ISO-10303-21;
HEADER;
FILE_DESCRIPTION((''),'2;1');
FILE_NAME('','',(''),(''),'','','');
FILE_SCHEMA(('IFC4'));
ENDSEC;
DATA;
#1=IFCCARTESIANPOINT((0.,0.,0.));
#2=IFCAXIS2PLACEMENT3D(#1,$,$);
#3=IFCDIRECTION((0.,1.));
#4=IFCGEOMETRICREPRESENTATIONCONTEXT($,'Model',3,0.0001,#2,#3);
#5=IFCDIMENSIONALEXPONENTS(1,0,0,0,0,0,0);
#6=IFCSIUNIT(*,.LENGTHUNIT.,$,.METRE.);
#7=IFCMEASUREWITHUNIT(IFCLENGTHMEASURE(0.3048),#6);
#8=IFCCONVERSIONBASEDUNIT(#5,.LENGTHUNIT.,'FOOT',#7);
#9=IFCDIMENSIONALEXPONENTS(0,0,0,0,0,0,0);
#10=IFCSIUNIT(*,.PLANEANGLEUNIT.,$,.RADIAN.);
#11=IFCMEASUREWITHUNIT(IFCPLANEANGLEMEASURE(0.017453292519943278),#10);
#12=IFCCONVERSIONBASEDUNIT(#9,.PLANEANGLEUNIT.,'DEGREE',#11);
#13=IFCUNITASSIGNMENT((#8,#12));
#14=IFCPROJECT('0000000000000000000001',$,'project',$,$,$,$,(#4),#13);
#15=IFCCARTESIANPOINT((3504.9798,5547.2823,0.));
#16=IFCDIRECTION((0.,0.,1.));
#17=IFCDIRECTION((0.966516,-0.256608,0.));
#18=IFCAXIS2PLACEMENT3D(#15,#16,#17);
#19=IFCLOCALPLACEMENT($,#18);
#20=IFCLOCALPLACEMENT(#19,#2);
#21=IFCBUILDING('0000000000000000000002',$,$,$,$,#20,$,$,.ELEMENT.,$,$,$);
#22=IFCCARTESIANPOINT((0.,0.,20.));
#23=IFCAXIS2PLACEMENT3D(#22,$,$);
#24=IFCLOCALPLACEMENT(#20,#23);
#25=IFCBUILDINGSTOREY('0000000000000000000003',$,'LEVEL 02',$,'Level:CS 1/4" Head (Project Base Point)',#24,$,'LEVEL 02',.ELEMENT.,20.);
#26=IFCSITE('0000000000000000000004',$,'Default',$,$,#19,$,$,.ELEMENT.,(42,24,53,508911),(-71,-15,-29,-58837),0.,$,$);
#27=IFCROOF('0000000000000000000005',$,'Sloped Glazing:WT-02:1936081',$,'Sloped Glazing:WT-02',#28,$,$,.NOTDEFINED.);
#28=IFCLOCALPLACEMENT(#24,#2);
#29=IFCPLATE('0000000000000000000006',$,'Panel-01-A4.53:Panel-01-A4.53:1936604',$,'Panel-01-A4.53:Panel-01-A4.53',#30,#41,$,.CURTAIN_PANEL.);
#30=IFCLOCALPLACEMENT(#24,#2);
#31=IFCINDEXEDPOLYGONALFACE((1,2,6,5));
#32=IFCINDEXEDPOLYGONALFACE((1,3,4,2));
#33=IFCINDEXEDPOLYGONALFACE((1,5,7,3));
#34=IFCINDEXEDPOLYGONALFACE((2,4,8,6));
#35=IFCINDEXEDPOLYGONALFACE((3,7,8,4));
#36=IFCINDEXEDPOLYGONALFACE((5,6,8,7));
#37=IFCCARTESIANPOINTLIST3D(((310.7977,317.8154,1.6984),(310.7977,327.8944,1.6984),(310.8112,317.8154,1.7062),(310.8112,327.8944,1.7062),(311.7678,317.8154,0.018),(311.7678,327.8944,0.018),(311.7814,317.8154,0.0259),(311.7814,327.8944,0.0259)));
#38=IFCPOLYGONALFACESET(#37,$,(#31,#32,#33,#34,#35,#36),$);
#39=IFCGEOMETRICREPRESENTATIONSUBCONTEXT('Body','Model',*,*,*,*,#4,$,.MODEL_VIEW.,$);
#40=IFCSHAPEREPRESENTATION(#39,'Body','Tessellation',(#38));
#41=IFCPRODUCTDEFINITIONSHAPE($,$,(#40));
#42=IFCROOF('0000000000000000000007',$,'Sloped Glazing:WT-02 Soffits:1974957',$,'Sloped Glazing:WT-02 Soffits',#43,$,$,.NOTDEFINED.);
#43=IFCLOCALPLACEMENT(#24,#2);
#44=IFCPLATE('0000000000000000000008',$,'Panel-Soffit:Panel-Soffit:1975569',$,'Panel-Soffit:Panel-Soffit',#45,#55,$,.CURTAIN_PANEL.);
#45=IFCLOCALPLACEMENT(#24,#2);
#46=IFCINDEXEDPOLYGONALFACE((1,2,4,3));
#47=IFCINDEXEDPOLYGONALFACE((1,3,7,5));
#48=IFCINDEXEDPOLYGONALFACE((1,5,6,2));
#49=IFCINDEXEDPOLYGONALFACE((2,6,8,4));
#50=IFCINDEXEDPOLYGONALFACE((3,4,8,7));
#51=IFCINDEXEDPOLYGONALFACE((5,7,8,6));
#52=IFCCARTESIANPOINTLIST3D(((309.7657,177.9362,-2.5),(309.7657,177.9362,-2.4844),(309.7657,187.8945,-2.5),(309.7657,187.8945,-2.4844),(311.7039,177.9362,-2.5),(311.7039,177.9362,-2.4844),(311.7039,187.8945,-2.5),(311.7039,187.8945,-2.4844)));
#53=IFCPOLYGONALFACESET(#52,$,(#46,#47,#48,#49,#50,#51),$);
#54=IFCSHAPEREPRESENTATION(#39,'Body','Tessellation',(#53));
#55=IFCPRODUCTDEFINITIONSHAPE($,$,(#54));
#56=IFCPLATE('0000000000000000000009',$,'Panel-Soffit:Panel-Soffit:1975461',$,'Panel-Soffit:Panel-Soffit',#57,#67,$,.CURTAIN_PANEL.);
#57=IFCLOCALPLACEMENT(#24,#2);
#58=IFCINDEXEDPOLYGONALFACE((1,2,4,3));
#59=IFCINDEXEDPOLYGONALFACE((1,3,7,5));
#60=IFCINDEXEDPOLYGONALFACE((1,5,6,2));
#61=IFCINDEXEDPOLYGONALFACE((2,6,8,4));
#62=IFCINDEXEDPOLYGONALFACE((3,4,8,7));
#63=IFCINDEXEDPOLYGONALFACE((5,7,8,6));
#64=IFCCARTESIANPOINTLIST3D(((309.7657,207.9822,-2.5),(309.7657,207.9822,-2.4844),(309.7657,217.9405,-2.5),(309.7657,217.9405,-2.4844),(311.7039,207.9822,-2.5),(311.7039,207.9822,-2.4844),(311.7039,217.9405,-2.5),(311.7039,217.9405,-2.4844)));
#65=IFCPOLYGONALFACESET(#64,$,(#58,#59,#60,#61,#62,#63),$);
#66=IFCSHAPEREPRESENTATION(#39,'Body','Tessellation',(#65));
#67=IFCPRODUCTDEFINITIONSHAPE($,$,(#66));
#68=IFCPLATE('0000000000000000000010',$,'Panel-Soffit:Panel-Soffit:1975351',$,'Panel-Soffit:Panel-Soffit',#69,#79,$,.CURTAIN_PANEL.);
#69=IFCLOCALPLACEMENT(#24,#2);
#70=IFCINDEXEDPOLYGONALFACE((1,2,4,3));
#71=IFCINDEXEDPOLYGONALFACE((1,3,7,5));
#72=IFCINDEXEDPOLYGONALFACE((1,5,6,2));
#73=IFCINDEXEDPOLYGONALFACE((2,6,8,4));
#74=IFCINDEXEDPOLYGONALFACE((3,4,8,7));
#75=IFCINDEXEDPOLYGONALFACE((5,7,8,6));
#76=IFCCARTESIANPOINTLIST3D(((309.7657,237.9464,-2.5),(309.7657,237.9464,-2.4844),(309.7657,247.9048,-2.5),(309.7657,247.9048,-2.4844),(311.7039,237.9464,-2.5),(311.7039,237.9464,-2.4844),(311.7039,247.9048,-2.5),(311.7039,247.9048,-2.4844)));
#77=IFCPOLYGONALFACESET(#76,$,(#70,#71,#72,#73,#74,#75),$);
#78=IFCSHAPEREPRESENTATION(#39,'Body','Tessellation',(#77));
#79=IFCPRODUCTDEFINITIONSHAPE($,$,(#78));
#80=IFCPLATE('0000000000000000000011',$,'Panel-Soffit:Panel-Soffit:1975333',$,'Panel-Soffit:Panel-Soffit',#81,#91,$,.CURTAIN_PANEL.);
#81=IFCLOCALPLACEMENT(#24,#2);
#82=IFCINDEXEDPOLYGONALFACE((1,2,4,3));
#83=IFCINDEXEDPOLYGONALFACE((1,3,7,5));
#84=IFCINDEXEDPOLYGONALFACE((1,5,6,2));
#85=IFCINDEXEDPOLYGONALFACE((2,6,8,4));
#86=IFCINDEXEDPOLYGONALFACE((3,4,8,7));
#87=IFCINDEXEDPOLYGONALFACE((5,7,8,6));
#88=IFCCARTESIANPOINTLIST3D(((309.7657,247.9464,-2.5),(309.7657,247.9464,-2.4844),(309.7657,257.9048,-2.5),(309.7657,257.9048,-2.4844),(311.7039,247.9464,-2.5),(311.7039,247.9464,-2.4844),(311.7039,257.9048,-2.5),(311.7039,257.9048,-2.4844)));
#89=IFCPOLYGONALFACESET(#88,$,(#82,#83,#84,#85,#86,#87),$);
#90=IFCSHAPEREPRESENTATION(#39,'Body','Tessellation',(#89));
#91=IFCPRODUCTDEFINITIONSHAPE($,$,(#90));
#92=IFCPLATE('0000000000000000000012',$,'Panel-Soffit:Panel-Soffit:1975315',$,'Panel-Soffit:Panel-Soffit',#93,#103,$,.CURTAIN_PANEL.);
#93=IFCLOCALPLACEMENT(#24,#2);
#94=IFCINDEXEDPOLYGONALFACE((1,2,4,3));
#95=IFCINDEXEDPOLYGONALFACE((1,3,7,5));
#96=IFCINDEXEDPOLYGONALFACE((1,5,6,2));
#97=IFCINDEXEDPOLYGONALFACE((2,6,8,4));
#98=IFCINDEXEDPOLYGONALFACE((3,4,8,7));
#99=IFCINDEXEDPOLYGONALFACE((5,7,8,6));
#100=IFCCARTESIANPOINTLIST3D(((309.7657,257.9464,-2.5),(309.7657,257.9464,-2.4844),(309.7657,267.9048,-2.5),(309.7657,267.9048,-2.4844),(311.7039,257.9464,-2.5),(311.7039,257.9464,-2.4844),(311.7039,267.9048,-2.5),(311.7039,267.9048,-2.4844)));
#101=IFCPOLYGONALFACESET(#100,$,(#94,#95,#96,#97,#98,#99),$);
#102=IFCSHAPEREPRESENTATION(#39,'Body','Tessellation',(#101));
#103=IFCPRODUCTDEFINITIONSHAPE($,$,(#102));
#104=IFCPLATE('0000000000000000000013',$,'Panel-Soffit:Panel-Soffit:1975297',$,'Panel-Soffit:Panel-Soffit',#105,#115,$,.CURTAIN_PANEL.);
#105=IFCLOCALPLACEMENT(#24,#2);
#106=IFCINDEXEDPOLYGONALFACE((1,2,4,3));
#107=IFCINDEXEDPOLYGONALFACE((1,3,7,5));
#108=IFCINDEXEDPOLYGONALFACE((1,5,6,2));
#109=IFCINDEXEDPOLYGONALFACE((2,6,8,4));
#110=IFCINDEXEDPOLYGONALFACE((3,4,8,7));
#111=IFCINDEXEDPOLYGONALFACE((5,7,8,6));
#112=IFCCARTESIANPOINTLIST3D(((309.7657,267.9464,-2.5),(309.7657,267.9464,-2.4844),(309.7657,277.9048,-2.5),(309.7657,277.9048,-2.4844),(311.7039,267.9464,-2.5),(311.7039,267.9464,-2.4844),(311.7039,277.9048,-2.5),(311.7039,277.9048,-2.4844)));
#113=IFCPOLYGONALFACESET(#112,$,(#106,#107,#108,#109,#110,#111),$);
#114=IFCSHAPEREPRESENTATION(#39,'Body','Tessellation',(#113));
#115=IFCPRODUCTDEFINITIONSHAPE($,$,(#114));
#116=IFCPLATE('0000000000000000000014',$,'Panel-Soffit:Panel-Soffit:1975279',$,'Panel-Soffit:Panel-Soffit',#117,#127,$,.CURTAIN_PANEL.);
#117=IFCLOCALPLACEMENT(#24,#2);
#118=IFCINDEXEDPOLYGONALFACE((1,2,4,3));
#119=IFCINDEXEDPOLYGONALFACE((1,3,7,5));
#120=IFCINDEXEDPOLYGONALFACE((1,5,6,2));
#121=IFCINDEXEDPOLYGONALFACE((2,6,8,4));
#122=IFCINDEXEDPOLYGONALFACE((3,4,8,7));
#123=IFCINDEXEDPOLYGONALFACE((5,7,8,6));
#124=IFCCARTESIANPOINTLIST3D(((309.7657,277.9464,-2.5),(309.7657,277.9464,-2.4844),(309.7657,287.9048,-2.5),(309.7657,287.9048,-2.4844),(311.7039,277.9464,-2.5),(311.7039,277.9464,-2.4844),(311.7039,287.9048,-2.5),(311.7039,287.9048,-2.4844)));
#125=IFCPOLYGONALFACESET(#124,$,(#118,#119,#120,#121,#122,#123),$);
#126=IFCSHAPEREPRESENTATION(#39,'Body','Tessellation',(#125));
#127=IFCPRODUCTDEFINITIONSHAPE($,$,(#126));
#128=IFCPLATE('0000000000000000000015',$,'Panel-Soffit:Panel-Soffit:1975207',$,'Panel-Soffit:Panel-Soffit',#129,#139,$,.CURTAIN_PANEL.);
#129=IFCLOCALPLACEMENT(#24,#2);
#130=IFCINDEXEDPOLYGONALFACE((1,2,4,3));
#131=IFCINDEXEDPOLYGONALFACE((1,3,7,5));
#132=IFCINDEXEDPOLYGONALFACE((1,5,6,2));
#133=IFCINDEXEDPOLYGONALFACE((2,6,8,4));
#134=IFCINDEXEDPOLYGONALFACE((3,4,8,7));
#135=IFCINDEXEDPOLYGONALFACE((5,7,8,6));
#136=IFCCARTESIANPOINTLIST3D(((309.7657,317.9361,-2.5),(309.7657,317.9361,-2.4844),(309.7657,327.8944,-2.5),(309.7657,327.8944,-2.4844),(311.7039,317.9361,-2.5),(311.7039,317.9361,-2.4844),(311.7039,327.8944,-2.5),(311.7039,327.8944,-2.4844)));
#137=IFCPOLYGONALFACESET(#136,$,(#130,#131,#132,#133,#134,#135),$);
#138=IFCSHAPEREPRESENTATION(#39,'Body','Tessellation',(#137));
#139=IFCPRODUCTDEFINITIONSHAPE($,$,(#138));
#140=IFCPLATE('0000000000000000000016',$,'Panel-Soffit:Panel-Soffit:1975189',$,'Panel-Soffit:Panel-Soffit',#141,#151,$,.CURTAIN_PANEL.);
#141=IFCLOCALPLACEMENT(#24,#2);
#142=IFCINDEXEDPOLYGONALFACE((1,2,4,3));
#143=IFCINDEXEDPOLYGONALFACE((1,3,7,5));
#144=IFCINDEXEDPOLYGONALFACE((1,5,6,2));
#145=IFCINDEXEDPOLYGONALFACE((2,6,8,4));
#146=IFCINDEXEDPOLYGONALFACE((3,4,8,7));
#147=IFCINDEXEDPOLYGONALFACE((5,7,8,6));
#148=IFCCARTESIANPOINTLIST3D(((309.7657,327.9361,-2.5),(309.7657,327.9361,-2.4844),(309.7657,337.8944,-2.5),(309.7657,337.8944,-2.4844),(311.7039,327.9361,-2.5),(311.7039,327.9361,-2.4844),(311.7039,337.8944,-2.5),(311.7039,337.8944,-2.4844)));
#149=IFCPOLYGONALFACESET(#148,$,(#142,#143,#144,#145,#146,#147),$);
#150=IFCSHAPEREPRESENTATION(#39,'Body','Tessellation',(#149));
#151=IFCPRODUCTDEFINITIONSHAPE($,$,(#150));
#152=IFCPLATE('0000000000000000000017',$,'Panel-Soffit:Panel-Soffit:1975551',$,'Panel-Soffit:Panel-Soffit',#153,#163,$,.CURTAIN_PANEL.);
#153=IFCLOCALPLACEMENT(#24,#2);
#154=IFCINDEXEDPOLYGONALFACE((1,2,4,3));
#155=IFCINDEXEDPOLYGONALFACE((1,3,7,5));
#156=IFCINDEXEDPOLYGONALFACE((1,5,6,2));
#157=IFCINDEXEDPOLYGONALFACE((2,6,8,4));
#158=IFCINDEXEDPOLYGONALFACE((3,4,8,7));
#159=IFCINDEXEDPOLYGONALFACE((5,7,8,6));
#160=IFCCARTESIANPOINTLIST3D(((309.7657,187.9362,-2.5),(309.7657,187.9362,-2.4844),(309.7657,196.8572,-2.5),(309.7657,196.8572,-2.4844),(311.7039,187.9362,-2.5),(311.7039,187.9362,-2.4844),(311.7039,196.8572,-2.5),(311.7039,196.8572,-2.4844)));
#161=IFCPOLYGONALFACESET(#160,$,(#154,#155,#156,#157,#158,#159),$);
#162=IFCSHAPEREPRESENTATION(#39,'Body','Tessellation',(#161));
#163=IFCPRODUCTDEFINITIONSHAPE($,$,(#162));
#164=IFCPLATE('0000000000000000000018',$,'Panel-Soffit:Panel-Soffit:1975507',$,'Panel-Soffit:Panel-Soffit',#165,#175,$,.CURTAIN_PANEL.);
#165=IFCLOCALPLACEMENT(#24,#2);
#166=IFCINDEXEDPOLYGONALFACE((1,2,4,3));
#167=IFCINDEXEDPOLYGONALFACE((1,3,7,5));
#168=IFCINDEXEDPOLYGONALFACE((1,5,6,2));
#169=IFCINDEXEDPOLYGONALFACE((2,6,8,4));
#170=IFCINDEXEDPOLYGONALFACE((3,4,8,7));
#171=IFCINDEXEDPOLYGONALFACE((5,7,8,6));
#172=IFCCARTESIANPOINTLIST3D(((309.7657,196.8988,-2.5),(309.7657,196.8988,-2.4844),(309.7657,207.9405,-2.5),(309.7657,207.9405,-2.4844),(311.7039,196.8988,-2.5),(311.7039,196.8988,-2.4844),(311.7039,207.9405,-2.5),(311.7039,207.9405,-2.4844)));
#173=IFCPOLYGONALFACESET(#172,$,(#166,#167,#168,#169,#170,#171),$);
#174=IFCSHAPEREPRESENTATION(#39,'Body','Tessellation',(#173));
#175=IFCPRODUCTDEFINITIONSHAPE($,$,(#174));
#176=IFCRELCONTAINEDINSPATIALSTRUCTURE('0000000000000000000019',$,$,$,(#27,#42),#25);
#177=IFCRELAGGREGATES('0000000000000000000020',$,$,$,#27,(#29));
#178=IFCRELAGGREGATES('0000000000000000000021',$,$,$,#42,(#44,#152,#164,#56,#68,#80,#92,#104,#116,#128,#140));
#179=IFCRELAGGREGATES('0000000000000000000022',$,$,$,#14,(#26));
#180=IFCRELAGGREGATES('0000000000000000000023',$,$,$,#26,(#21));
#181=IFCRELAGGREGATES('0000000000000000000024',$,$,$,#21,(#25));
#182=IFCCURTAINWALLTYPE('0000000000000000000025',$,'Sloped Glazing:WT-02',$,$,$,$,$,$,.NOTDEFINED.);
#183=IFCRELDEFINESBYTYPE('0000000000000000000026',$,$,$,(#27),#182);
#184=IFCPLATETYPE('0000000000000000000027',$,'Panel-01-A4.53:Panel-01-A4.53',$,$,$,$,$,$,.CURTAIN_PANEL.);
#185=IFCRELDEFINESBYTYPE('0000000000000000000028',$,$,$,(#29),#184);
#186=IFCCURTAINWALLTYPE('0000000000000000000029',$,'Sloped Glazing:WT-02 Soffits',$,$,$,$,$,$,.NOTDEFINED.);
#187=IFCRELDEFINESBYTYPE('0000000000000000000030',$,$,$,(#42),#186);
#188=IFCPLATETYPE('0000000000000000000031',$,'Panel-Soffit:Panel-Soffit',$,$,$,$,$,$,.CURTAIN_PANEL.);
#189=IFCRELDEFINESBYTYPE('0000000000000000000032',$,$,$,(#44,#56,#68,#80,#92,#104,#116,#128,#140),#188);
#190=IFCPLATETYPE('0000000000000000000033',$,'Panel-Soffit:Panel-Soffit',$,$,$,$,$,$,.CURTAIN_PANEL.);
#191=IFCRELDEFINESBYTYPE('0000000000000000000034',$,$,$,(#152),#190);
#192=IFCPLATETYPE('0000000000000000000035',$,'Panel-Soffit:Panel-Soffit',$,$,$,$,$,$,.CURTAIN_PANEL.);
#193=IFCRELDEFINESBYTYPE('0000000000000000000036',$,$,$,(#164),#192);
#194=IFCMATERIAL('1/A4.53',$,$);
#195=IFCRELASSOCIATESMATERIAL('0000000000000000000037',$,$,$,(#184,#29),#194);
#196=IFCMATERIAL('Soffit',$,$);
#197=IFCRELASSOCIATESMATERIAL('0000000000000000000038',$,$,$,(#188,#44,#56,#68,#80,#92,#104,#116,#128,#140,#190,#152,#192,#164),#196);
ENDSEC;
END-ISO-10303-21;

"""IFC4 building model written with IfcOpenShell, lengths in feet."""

from ifc_helpers import new_model, entity, si_unit, converted_unit, direction, frame, origin, place, context, subcontext, project, spatial, indexed_curve, outline, extrude, source, transform, mapped, material, type_object, type_shapes, element, aggregate, save


model = new_model("IFC4")

# Units and contexts
model_context = context("Model", 3, precision=0.0001, world=origin(), true_north=direction((0.0, 1.0)))
body_context = subcontext(model_context, "Body", "Model", "MODEL_VIEW")
ifc_project = project(units=[converted_unit("LENGTHUNIT", "FOOT", entity("IfcLengthMeasure", 0.3048), si_unit("LENGTHUNIT", "METRE"), dimensions=[1, 0, 0, 0, 0, 0, 0]), converted_unit("PLANEANGLEUNIT", "DEGREE", entity("IfcPlaneAngleMeasure", 0.017453292519943278), si_unit("PLANEANGLEUNIT", "RADIAN"), dimensions=[0, 0, 0, 0, 0, 0, 0])], contexts=[model_context])

# Site, building, storey
site_placement = place(None, frame((3504.9798, 5547.2823, 0.0), z_axis=(0.0, 0.0, 1.0), x_axis=(0.966516, -0.256608, 0.0)))
site = spatial("IfcSite", under=ifc_project, at=site_placement, Name="Default", CompositionType="ELEMENT", RefLatitude=(42, 24, 53, 508911), RefLongitude=(-71, -15, -29, -58837), RefElevation=0.0)
building_placement = place(site_placement, origin())
building = spatial("IfcBuilding", under=site, at=building_placement, CompositionType="ELEMENT")
storey_placement = place(building_placement, frame((0.0, 0.0, 20.0)))
storey = spatial("IfcBuildingStorey", under=building, at=storey_placement, Name="LEVEL 02", ObjectType="Level:CS 1/4\" Head (Project Base Point)", LongName="LEVEL 02", CompositionType="ELEMENT", Elevation=20.0)

# Shared definitions
curtain_wall_type_1 = type_object("IfcCurtainWallType", Name="Sloped Glazing:WT-02 Soffits", PredefinedType="NOTDEFINED")
ifc_material_1 = material(Name="Soffit")

# Roof, plate
curtain_wall_type_2 = type_object("IfcCurtainWallType", Name="Sloped Glazing:WT-02", PredefinedType="NOTDEFINED")
roof_1_placement = place(storey_placement, frame((0.0, 0.0, -20.0)))
roof_1 = element("IfcRoof", 1, at=roof_1_placement, inside=storey, type_object=curtain_wall_type_2, Name="Sloped Glazing:WT-02:1936081", ObjectType="Sloped Glazing:WT-02", PredefinedType="NOTDEFINED")
ifc_material_2 = material(Name="1/A4.53")
plate_type_1 = type_object("IfcPlateType", Name="Panel-01-A4.53:Panel-01-A4.53", PredefinedType="CURTAIN_PANEL", material=ifc_material_2)
shared_shape_1 = source(origin(), body_context, "Body", "SweptSolid", [
    extrude(outline(indexed_curve([(-0.0078, -5.0395), (0.0078, -5.0395), (0.0078, 5.0395), (-0.0078, 5.0395), (-0.0078, -5.0395)], self_intersect=False)), frame((0.0, -0.0078, 0.0208), z_axis=(0.0, 0.0, 1.0), x_axis=(0.0, -1.0, 0.0)), (0.0, 0.0, 1.0), 1.9403),
])
type_shapes(plate_type_1, [shared_shape_1])
plate_1_placement = place(roof_1_placement, frame((311.7783, 322.8549, 20.0), z_axis=(-0.5, 0.0, 0.866025), x_axis=(0.0, 1.0, 0.0)))
plate_1 = element("IfcPlate", 2, at=plate_1_placement, type_object=plate_type_1, material=ifc_material_2, Name="Panel-01-A4.53:Panel-01-A4.53:1936604", ObjectType="Panel-01-A4.53:Panel-01-A4.53", PredefinedType="CURTAIN_PANEL", context=body_context, shape_type="MappedRepresentation", body=[
    mapped(shared_shape_1, transform((0.0, 0.0, 0.0), scale=1.0)),
])
aggregate(roof_1, [plate_1])

# Roof, plates
roof_2_placement = place(storey_placement, frame((0.0, 0.0, -20.0)))
roof_2 = element("IfcRoof", 3, at=roof_2_placement, inside=storey, type_object=curtain_wall_type_1, Name="Sloped Glazing:WT-02 Soffits:1974957", ObjectType="Sloped Glazing:WT-02 Soffits", PredefinedType="NOTDEFINED")
plate_type_2 = type_object("IfcPlateType", Name="Panel-Soffit:Panel-Soffit", PredefinedType="CURTAIN_PANEL", material=ifc_material_1)
shared_shape_2 = source(origin(), body_context, "Body", "SweptSolid", [
    extrude(outline(indexed_curve([(-0.0078, -0.9691), (0.0078, -0.9691), (0.0078, 0.9691), (-0.0078, 0.9691), (-0.0078, -0.9691)], self_intersect=False)), frame((0.0, -0.0078, 0.0208), z_axis=(0.0, 0.0, 1.0), x_axis=(0.0, -1.0, 0.0)), (0.0, 0.0, 1.0), 9.9583),
])
type_shapes(plate_type_2, [shared_shape_2])
plate_2_placement = place(roof_2_placement, frame((310.7348, 177.9154, 17.5), z_axis=(0.0, 1.0, 0.0), x_axis=(1.0, 0.0, 0.0)))
plate_2 = element("IfcPlate", 4, at=plate_2_placement, type_object=plate_type_2, material=ifc_material_1, Name="Panel-Soffit:Panel-Soffit:1975569", ObjectType="Panel-Soffit:Panel-Soffit", PredefinedType="CURTAIN_PANEL", context=body_context, shape_type="MappedRepresentation", body=[
    mapped(shared_shape_2, transform((0.0, 0.0, 0.0), scale=1.0)),
])
plate_3_placement = place(roof_2_placement, frame((310.7348, 207.9613, 17.5), z_axis=(0.0, 1.0, 0.0), x_axis=(1.0, 0.0, 0.0)))
plate_3 = element("IfcPlate", 5, at=plate_3_placement, type_object=plate_type_2, material=ifc_material_1, Name="Panel-Soffit:Panel-Soffit:1975461", ObjectType="Panel-Soffit:Panel-Soffit", PredefinedType="CURTAIN_PANEL", context=body_context, shape_type="MappedRepresentation", body=[
    mapped(shared_shape_2, transform((0.0, 0.0, 0.0), scale=1.0)),
])
plate_4_placement = place(roof_2_placement, frame((310.7348, 237.9256, 17.5), z_axis=(0.0, 1.0, 0.0), x_axis=(1.0, 0.0, 0.0)))
plate_4 = element("IfcPlate", 6, at=plate_4_placement, type_object=plate_type_2, material=ifc_material_1, Name="Panel-Soffit:Panel-Soffit:1975351", ObjectType="Panel-Soffit:Panel-Soffit", PredefinedType="CURTAIN_PANEL", context=body_context, shape_type="MappedRepresentation", body=[
    mapped(shared_shape_2, transform((0.0, 0.0, 0.0), scale=1.0)),
])
plate_5_placement = place(roof_2_placement, frame((310.7348, 247.9256, 17.5), z_axis=(0.0, 1.0, 0.0), x_axis=(1.0, 0.0, 0.0)))
plate_5 = element("IfcPlate", 7, at=plate_5_placement, type_object=plate_type_2, material=ifc_material_1, Name="Panel-Soffit:Panel-Soffit:1975333", ObjectType="Panel-Soffit:Panel-Soffit", PredefinedType="CURTAIN_PANEL", context=body_context, shape_type="MappedRepresentation", body=[
    mapped(shared_shape_2, transform((0.0, 0.0, 0.0), scale=1.0)),
])
plate_6_placement = place(roof_2_placement, frame((310.7348, 257.9256, 17.5), z_axis=(0.0, 1.0, 0.0), x_axis=(1.0, 0.0, 0.0)))
plate_6 = element("IfcPlate", 8, at=plate_6_placement, type_object=plate_type_2, material=ifc_material_1, Name="Panel-Soffit:Panel-Soffit:1975315", ObjectType="Panel-Soffit:Panel-Soffit", PredefinedType="CURTAIN_PANEL", context=body_context, shape_type="MappedRepresentation", body=[
    mapped(shared_shape_2, transform((0.0, 0.0, 0.0), scale=1.0)),
])
plate_7_placement = place(roof_2_placement, frame((310.7348, 267.9256, 17.5), z_axis=(0.0, 1.0, 0.0), x_axis=(1.0, 0.0, 0.0)))
plate_7 = element("IfcPlate", 9, at=plate_7_placement, type_object=plate_type_2, material=ifc_material_1, Name="Panel-Soffit:Panel-Soffit:1975297", ObjectType="Panel-Soffit:Panel-Soffit", PredefinedType="CURTAIN_PANEL", context=body_context, shape_type="MappedRepresentation", body=[
    mapped(shared_shape_2, transform((0.0, 0.0, 0.0), scale=1.0)),
])
plate_8_placement = place(roof_2_placement, frame((310.7348, 277.9256, 17.5), z_axis=(0.0, 1.0, 0.0), x_axis=(1.0, 0.0, 0.0)))
plate_8 = element("IfcPlate", 10, at=plate_8_placement, type_object=plate_type_2, material=ifc_material_1, Name="Panel-Soffit:Panel-Soffit:1975279", ObjectType="Panel-Soffit:Panel-Soffit", PredefinedType="CURTAIN_PANEL", context=body_context, shape_type="MappedRepresentation", body=[
    mapped(shared_shape_2, transform((0.0, 0.0, 0.0), scale=1.0)),
])
plate_9_placement = place(roof_2_placement, frame((310.7348, 317.9153, 17.5), z_axis=(0.0, 1.0, 0.0), x_axis=(1.0, 0.0, 0.0)))
plate_9 = element("IfcPlate", 11, at=plate_9_placement, type_object=plate_type_2, material=ifc_material_1, Name="Panel-Soffit:Panel-Soffit:1975207", ObjectType="Panel-Soffit:Panel-Soffit", PredefinedType="CURTAIN_PANEL", context=body_context, shape_type="MappedRepresentation", body=[
    mapped(shared_shape_2, transform((0.0, 0.0, 0.0), scale=1.0)),
])
plate_10_placement = place(roof_2_placement, frame((310.7348, 327.9153, 17.5), z_axis=(0.0, 1.0, 0.0), x_axis=(1.0, 0.0, 0.0)))
plate_10 = element("IfcPlate", 12, at=plate_10_placement, type_object=plate_type_2, material=ifc_material_1, Name="Panel-Soffit:Panel-Soffit:1975189", ObjectType="Panel-Soffit:Panel-Soffit", PredefinedType="CURTAIN_PANEL", context=body_context, shape_type="MappedRepresentation", body=[
    mapped(shared_shape_2, transform((0.0, 0.0, 0.0), scale=1.0)),
])
plate_type_3 = type_object("IfcPlateType", Name="Panel-Soffit:Panel-Soffit", PredefinedType="CURTAIN_PANEL", material=ifc_material_1)
shared_shape_3 = source(origin(), body_context, "Body", "SweptSolid", [
    extrude(outline(indexed_curve([(-0.0078, -0.9691), (0.0078, -0.9691), (0.0078, 0.9691), (-0.0078, 0.9691), (-0.0078, -0.9691)], self_intersect=False)), frame((0.0, -0.0078, 0.0208), z_axis=(0.0, 0.0, 1.0), x_axis=(0.0, -1.0, 0.0)), (0.0, 0.0, 1.0), 8.921),
])
type_shapes(plate_type_3, [shared_shape_3])
plate_11_placement = place(roof_2_placement, frame((310.7348, 187.9154, 17.5), z_axis=(0.0, 1.0, 0.0), x_axis=(1.0, 0.0, 0.0)))
plate_11 = element("IfcPlate", 13, at=plate_11_placement, type_object=plate_type_3, material=ifc_material_1, Name="Panel-Soffit:Panel-Soffit:1975551", ObjectType="Panel-Soffit:Panel-Soffit", PredefinedType="CURTAIN_PANEL", context=body_context, shape_type="MappedRepresentation", body=[
    mapped(shared_shape_3, transform((0.0, 0.0, 0.0), scale=1.0)),
])
plate_type_4 = type_object("IfcPlateType", Name="Panel-Soffit:Panel-Soffit", PredefinedType="CURTAIN_PANEL", material=ifc_material_1)
shared_shape_4 = source(origin(), body_context, "Body", "SweptSolid", [
    extrude(outline(indexed_curve([(-0.0078, -0.9691), (0.0078, -0.9691), (0.0078, 0.9691), (-0.0078, 0.9691), (-0.0078, -0.9691)], self_intersect=False)), frame((0.0, -0.0078, 0.0208), z_axis=(0.0, 0.0, 1.0), x_axis=(0.0, -1.0, 0.0)), (0.0, 0.0, 1.0), 11.0417),
])
type_shapes(plate_type_4, [shared_shape_4])
plate_12_placement = place(roof_2_placement, frame((310.7348, 196.878, 17.5), z_axis=(0.0, 1.0, 0.0), x_axis=(1.0, 0.0, 0.0)))
plate_12 = element("IfcPlate", 14, at=plate_12_placement, type_object=plate_type_4, material=ifc_material_1, Name="Panel-Soffit:Panel-Soffit:1975507", ObjectType="Panel-Soffit:Panel-Soffit", PredefinedType="CURTAIN_PANEL", context=body_context, shape_type="MappedRepresentation", body=[
    mapped(shared_shape_4, transform((0.0, 0.0, 0.0), scale=1.0)),
])
aggregate(roof_2, [plate_2, plate_11, plate_12, plate_3, plate_4, plate_5, plate_6, plate_7, plate_8, plate_9, plate_10])

save(model, "model.ifc")
